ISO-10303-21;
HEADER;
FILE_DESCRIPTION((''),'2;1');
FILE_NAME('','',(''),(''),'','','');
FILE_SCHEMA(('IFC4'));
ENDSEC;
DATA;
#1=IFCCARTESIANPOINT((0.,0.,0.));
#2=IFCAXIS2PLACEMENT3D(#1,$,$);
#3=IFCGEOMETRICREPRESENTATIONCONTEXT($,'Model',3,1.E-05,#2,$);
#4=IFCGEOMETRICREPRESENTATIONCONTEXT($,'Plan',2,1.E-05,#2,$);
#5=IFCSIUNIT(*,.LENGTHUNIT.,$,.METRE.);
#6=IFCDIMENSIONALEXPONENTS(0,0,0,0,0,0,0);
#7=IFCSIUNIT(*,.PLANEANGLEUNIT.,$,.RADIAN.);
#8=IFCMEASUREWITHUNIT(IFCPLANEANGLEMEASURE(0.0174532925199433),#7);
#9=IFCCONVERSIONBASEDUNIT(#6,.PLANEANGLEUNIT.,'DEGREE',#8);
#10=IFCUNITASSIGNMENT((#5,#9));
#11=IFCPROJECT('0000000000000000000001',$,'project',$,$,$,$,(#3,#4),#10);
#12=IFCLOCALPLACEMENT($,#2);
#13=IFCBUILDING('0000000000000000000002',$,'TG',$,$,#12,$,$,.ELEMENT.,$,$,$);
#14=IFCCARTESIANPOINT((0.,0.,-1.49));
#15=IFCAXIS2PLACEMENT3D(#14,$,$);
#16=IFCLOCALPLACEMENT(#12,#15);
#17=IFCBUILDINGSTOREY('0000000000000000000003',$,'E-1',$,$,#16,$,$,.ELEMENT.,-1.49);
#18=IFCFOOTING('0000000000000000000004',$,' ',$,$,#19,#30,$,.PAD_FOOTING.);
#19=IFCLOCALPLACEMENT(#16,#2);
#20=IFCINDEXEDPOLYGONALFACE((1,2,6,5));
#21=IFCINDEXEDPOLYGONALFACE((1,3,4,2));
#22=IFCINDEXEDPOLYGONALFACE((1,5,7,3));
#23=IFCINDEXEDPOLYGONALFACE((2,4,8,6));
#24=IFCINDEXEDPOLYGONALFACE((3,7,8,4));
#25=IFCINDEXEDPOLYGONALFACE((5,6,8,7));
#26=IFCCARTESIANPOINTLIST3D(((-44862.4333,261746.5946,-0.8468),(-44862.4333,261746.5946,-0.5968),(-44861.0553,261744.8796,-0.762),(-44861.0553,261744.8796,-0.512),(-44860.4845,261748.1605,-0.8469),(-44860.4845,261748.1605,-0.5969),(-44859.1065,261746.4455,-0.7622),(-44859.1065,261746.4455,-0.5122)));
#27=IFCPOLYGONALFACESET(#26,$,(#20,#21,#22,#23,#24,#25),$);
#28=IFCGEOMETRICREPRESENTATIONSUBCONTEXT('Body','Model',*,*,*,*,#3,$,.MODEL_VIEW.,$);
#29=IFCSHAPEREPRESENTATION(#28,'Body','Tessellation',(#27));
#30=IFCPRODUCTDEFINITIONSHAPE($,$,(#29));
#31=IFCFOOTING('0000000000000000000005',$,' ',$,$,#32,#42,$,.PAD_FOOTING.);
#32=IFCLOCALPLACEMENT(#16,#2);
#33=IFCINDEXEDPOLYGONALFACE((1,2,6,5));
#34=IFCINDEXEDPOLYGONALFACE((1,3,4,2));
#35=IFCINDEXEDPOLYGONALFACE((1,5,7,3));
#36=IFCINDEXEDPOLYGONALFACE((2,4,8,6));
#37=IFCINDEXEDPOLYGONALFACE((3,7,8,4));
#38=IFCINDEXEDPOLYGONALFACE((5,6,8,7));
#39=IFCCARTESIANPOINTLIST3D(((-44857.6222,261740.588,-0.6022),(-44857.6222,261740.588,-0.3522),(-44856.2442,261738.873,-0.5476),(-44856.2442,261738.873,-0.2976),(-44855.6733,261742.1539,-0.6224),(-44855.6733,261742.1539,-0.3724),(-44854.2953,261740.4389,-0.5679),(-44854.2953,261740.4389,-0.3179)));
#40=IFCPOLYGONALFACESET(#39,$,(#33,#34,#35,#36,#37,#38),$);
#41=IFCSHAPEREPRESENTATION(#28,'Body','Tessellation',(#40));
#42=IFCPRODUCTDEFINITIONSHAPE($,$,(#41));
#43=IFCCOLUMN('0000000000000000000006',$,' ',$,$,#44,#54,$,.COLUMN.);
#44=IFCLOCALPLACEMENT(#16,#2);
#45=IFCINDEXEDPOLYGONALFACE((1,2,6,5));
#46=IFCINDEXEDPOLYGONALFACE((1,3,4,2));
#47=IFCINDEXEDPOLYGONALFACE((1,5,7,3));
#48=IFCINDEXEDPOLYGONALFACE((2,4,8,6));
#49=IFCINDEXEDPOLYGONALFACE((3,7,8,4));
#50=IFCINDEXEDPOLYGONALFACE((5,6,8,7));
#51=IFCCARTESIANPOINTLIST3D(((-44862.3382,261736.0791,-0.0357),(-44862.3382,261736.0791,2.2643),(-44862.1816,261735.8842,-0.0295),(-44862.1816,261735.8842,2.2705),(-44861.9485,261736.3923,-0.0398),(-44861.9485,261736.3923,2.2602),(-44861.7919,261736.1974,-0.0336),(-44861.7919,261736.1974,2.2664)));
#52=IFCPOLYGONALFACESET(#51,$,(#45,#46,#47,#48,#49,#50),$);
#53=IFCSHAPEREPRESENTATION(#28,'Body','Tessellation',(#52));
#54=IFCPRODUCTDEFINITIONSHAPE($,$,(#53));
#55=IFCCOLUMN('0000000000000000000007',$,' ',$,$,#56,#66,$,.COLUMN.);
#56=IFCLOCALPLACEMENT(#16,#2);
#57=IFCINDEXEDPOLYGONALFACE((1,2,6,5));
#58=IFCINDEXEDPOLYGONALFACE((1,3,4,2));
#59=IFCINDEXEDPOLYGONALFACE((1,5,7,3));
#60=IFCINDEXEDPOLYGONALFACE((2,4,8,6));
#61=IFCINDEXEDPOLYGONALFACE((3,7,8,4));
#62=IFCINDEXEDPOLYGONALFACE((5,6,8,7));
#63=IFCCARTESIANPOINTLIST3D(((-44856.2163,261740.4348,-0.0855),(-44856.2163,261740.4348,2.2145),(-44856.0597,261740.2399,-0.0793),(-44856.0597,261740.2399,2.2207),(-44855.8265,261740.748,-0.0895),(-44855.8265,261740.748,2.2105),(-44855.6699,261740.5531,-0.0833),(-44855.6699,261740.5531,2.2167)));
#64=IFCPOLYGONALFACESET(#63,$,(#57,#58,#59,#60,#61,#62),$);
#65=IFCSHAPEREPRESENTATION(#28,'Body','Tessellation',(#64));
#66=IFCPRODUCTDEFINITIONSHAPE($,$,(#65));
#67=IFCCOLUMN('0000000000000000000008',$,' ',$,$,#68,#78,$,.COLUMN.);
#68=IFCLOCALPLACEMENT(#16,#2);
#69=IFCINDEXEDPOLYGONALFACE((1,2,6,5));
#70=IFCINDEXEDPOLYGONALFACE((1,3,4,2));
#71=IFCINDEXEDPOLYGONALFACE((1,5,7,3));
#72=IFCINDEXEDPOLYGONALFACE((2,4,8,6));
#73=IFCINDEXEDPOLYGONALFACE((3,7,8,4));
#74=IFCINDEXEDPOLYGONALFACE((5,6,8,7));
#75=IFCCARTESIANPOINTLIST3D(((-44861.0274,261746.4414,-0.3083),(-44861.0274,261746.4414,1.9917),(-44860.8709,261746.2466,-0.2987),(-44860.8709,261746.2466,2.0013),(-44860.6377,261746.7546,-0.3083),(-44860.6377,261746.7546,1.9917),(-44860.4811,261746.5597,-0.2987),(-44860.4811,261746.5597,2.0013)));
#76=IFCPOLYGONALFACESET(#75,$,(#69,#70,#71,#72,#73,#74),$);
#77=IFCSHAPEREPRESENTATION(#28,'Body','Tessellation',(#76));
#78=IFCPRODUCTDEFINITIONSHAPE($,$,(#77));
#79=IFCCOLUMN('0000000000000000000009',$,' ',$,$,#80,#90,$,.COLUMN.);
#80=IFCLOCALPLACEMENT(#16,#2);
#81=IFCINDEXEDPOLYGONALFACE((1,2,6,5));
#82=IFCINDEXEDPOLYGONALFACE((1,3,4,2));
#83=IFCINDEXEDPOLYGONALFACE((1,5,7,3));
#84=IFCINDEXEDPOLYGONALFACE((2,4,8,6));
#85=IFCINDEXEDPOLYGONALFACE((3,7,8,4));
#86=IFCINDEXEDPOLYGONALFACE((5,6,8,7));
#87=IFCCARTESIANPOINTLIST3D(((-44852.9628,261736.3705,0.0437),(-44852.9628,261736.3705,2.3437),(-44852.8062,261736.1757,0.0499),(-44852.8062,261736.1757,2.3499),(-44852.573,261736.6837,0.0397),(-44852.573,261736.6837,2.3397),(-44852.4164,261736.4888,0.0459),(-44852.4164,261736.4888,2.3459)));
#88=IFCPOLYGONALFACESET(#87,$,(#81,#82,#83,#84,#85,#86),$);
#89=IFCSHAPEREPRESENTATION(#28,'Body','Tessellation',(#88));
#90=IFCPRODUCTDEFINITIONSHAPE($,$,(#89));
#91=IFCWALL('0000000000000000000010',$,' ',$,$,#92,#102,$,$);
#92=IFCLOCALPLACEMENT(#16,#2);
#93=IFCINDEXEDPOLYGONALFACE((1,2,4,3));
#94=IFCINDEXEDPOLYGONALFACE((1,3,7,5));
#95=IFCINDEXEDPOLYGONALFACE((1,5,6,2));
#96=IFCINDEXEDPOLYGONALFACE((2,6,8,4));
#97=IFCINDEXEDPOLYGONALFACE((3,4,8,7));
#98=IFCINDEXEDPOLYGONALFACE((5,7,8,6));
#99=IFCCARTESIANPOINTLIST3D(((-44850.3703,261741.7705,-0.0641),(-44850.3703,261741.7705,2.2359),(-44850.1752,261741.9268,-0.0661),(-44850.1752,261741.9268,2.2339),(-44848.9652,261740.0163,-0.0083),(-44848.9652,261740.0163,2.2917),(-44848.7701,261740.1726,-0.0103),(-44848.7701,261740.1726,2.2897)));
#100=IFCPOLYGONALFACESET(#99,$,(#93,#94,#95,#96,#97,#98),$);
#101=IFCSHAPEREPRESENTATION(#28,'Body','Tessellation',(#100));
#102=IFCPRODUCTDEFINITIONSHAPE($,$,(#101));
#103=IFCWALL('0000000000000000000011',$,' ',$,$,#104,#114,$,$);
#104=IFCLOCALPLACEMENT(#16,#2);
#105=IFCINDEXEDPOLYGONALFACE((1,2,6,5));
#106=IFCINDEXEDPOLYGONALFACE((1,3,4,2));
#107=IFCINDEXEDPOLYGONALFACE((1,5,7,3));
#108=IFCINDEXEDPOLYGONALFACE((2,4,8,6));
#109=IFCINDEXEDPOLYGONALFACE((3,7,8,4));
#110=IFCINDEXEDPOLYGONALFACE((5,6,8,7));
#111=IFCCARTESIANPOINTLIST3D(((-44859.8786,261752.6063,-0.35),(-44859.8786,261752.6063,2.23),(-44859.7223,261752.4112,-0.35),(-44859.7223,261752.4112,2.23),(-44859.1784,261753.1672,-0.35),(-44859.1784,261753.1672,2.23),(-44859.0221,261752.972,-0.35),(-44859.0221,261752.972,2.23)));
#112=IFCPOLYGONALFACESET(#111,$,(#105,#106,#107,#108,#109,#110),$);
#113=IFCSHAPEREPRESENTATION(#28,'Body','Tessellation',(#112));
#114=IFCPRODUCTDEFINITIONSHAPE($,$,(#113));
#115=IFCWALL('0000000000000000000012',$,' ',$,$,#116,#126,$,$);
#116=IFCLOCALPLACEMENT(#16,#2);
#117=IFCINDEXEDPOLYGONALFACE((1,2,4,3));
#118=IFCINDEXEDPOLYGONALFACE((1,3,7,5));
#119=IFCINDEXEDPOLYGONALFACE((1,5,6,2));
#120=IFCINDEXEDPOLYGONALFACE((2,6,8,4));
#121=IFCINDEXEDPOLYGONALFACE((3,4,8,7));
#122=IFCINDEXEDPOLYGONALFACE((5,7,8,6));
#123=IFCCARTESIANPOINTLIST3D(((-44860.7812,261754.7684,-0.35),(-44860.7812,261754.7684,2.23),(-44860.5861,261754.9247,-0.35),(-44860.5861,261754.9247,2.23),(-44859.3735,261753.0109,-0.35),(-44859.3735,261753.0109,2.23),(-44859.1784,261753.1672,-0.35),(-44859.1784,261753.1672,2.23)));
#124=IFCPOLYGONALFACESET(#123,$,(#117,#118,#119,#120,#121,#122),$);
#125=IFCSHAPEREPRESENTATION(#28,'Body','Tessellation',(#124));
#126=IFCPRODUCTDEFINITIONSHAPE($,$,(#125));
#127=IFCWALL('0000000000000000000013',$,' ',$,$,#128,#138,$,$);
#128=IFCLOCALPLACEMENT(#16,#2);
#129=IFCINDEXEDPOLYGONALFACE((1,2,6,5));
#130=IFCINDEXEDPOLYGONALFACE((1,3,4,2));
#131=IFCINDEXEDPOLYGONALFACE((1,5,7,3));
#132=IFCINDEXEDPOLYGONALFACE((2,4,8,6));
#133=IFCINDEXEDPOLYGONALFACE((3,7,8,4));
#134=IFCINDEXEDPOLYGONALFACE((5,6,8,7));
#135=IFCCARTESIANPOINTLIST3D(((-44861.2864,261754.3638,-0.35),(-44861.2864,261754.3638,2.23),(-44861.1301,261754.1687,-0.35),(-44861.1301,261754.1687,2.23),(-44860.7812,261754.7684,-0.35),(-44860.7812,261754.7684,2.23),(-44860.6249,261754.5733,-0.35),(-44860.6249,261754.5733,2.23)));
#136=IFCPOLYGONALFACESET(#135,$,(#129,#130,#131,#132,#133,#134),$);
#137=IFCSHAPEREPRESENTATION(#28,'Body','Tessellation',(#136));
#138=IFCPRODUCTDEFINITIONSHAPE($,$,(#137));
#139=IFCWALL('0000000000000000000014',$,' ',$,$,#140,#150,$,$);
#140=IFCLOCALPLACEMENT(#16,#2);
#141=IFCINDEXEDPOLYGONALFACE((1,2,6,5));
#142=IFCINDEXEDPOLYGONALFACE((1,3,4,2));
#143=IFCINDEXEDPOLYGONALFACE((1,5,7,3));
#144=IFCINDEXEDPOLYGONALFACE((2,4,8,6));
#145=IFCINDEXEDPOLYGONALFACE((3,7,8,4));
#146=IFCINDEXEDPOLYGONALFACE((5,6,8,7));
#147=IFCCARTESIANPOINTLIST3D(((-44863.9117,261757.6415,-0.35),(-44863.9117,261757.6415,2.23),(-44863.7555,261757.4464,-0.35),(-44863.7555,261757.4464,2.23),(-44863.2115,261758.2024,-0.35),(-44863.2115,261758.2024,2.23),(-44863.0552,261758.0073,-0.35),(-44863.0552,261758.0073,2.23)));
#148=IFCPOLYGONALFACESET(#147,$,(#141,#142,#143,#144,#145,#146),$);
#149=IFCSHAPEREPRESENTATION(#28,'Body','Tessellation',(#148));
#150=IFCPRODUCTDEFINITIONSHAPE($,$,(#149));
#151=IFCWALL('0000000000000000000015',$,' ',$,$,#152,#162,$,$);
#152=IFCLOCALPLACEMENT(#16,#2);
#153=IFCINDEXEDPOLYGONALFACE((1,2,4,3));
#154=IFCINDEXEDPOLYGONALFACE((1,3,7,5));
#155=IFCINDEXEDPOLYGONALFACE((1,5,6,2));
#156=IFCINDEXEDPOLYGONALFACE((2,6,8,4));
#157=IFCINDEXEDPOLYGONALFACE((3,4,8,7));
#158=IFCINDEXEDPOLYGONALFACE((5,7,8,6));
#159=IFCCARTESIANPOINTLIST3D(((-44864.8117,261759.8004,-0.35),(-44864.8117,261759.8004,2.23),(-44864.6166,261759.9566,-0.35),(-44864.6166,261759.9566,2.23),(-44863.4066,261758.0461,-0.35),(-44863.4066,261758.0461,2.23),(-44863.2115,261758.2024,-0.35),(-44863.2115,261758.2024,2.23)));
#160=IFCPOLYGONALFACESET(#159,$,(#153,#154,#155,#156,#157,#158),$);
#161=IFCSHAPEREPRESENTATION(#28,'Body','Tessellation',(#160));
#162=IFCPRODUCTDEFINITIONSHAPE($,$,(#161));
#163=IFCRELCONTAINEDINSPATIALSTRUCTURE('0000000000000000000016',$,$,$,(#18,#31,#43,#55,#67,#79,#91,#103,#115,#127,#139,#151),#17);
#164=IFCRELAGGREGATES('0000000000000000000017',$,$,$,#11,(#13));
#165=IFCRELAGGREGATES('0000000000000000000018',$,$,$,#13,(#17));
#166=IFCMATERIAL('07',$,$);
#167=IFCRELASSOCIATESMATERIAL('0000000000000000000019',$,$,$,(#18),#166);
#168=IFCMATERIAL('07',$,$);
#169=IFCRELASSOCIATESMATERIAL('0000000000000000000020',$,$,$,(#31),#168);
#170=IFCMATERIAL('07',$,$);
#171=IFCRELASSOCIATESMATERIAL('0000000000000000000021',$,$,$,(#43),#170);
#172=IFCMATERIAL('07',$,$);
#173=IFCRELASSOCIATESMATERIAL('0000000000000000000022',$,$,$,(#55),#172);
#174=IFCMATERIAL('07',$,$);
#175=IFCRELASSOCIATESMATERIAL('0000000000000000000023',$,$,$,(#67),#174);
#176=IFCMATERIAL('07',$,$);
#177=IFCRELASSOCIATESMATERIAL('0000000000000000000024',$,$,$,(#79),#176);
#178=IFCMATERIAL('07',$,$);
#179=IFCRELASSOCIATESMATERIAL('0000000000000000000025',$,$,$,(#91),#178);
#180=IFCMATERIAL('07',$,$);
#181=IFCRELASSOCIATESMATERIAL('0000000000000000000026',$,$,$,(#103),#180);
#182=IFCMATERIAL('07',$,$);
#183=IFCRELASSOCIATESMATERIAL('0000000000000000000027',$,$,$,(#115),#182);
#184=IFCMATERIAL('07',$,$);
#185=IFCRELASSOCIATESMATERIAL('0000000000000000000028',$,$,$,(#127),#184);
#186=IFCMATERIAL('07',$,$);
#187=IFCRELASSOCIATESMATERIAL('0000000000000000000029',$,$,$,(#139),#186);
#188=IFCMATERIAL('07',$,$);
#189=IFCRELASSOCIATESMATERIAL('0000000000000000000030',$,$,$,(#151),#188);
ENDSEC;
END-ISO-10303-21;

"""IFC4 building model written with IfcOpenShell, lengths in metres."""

from ifc_helpers import new_model, entity, si_unit, converted_unit, frame, frame_2d, origin, origin_with_axes, place, context, subcontext, project, spatial, rectangle, extrude, clip, halfspace, material, element, save


model = new_model("IFC4")

# Units and contexts
model_context = context("Model", 3, precision=1e-05, world=origin())
plan_context = context("Plan", 2, precision=1e-05, world=origin())
body_context = subcontext(model_context, "Body", "Model", "MODEL_VIEW")
ifc_project = project(units=[si_unit("LENGTHUNIT", "METRE"), converted_unit("PLANEANGLEUNIT", "DEGREE", entity("IfcPlaneAngleMeasure", 0.0174532925199433), si_unit("PLANEANGLEUNIT", "RADIAN"), dimensions=[0, 0, 0, 0, 0, 0, 0])], contexts=[model_context, plan_context])

# Building, storey
building_placement = place(None, origin())
building = spatial("IfcBuilding", under=ifc_project, at=building_placement, Name="TG", CompositionType="ELEMENT")
storey_placement = place(building_placement, frame((0.0, 0.0, -1.49)))
storey = spatial("IfcBuildingStorey", under=building, at=storey_placement, Name="E-1", CompositionType="ELEMENT", Elevation=-1.49)

# Footings
ifc_material_1 = material(Name="07")
footing_1_placement = place(storey_placement, frame((-44862.4333, 261744.8796, -0.8469)))
element("IfcFooting", 1, at=footing_1_placement, inside=storey, material=ifc_material_1, Name=" ", PredefinedType="PAD_FOOTING", context=body_context, shape_type="Clipping", body=[
    clip(clip(extrude(rectangle(XDim=2.5, YDim=2.2, at=frame_2d((0.2854, 1.6404), x_axis=(0.779531, 0.626364))), frame((1.378, 0.0, 0.0), z_axis=(0.0, 0.0, 1.0), x_axis=(1.0, 0.0, 0.0)), (0.0, 0.0, 1.0), 0.3349), halfspace(frame((1.6634, 1.6404, 0.0425), z_axis=(-0.024077, 0.03006, 0.999258), x_axis=(0.625899, -0.778953, 0.038513)), True)), halfspace(frame((1.6634, 1.6404, 0.2925), z_axis=(0.024077, -0.03006, -0.999258), x_axis=(0.779531, 0.626364, -0.00006)), True)),
])
ifc_material_2 = material(Name="07")
footing_2_placement = place(storey_placement, frame((-44857.6222, 261738.873, -0.6224)))
element("IfcFooting", 2, at=footing_2_placement, inside=storey, material=ifc_material_2, Name=" ", PredefinedType="PAD_FOOTING", context=body_context, shape_type="Clipping", body=[
    clip(clip(extrude(rectangle(XDim=2.5, YDim=2.2, at=frame_2d((0.2854, 1.6404), x_axis=(0.779531, 0.626364))), frame((1.378, 0.0, 0.0), z_axis=(0.0, 0.0, 1.0), x_axis=(1.0, 0.0, 0.0)), (0.0, 0.0, 1.0), 0.3248), halfspace(frame((1.6634, 1.6404, 0.0374), z_axis=(-0.009231, 0.024393, 0.99966), x_axis=(0.626171, -0.779291, 0.024798)), True)), halfspace(frame((1.6634, 1.6404, 0.2874), z_axis=(0.009231, -0.024393, -0.99966), x_axis=(0.779505, 0.626343, -0.008086)), True)),
])

# Columns
ifc_material_3 = material(Name="07")
column_1_placement = place(storey_placement, frame((-44861.9485, 261736.3923, -0.0398)))
element("IfcColumn", 3, at=column_1_placement, inside=storey, material=ifc_material_3, Name=" ", PredefinedType="COLUMN", context=body_context, shape_type="Clipping", body=[
    clip(clip(extrude(rectangle(XDim=0.5, YDim=0.25, at=frame_2d((-0.1166, -0.254), x_axis=(-0.779531, -0.626364))), origin_with_axes(), (0.0, 0.0, 1.0), 2.3102), halfspace(frame((-0.1166, -0.254, 0.0051), z_axis=(-0.009231, 0.024393, 0.99966), x_axis=(-0.626171, 0.779291, -0.024798)), True)), halfspace(frame((-0.1166, -0.254, 2.3051), z_axis=(0.009231, -0.024393, -0.99966), x_axis=(-0.779505, -0.626343, 0.008086)), True)),
])
ifc_material_4 = material(Name="07")
column_2_placement = place(storey_placement, frame((-44855.8265, 261740.748, -0.0895)))
element("IfcColumn", 4, at=column_2_placement, inside=storey, material=ifc_material_4, Name=" ", PredefinedType="COLUMN", context=body_context, shape_type="Clipping", body=[
    clip(clip(extrude(rectangle(XDim=0.5, YDim=0.25, at=frame_2d((-0.1166, -0.254), x_axis=(-0.779531, -0.626364))), origin_with_axes(), (0.0, 0.0, 1.0), 2.3102), halfspace(frame((-0.1166, -0.254, 0.0051), z_axis=(-0.009231, 0.024393, 0.99966), x_axis=(-0.626171, 0.779291, -0.024798)), True)), halfspace(frame((-0.1166, -0.254, 2.3051), z_axis=(0.009231, -0.024393, -0.99966), x_axis=(-0.779505, -0.626343, 0.008086)), True)),
])
ifc_material_5 = material(Name="07")
column_3_placement = place(storey_placement, frame((-44860.6377, 261746.7546, -0.3083)))
element("IfcColumn", 5, at=column_3_placement, inside=storey, material=ifc_material_5, Name=" ", PredefinedType="COLUMN", context=body_context, shape_type="Clipping", body=[
    clip(clip(extrude(rectangle(XDim=0.5, YDim=0.25, at=frame_2d((-0.1166, -0.254), x_axis=(-0.779531, -0.626364))), origin_with_axes(), (0.0, 0.0, 1.0), 2.3097), halfspace(frame((-0.1166, -0.254, 0.0048), z_axis=(-0.024077, 0.03006, 0.999258), x_axis=(-0.625899, 0.778953, -0.038513)), True)), halfspace(frame((-0.1166, -0.254, 2.3048), z_axis=(0.024077, -0.03006, -0.999258), x_axis=(-0.779531, -0.626364, 0.00006)), True)),
])
ifc_material_6 = material(Name="07")
column_4_placement = place(storey_placement, frame((-44852.573, 261736.6837, 0.0397)))
element("IfcColumn", 6, at=column_4_placement, inside=storey, material=ifc_material_6, Name=" ", PredefinedType="COLUMN", context=body_context, shape_type="Clipping", body=[
    clip(clip(extrude(rectangle(XDim=0.5, YDim=0.25, at=frame_2d((-0.1166, -0.254), x_axis=(-0.779531, -0.626364))), origin_with_axes(), (0.0, 0.0, 1.0), 2.3102), halfspace(frame((-0.1166, -0.254, 0.0051), z_axis=(-0.009231, 0.024393, 0.99966), x_axis=(-0.626171, 0.779291, -0.024798)), True)), halfspace(frame((-0.1166, -0.254, 2.3051), z_axis=(0.009231, -0.024393, -0.99966), x_axis=(-0.779505, -0.626343, 0.008086)), True)),
])

# Walls
ifc_material_7 = material(Name="07")
wall_1_placement = place(storey_placement, frame((-44848.7701, 261740.1726, -0.0661), z_axis=(0.0, 0.0, 1.0), x_axis=(-0.625159, 0.780498, 0.0)))
element("IfcWall", 7, at=wall_1_placement, inside=storey, material=ifc_material_7, Name=" ", context=body_context, shape_type="Clipping", body=[
    clip(clip(extrude(rectangle(XDim=2.2476, YDim=0.25, at=frame_2d((1.1238, 0.125), x_axis=(1.0, 0.0))), origin_with_axes(), (0.0, 0.0, 1.0), 2.3578), halfspace(frame((1.1238, 0.125, 0.0289), z_axis=(0.02481, -0.008045, 0.99966), x_axis=(0.0, -0.999968, -0.008047)), True)), halfspace(frame((1.1238, 0.125, 2.3289), z_axis=(-0.02481, 0.008045, -0.99966), x_axis=(0.999692, 0.0, -0.02481)), True)),
])
ifc_material_8 = material(Name="07")
wall_2_placement = place(storey_placement, frame((-44859.7223, 261752.4112, -0.35), z_axis=(0.0, 0.0, 1.0), x_axis=(0.780498, 0.625159, 0.0)))
element("IfcWall", 8, at=wall_2_placement, inside=storey, material=ifc_material_8, Name=" ", context=body_context, shape_type="SweptSolid", body=[
    extrude(rectangle(XDim=0.8972, YDim=0.25, at=frame_2d((0.4486, 0.125), x_axis=(1.0, 0.0))), origin_with_axes(), (0.0, 0.0, 1.0), 2.58),
])
ifc_material_9 = material(Name="07")
wall_3_placement = place(storey_placement, frame((-44859.1784, 261753.1672, -0.35), z_axis=(0.0, 0.0, 1.0), x_axis=(-0.625159, 0.780498, 0.0)))
element("IfcWall", 9, at=wall_3_placement, inside=storey, material=ifc_material_9, Name=" ", context=body_context, shape_type="SweptSolid", body=[
    extrude(rectangle(XDim=2.2518, YDim=0.25, at=frame_2d((1.1259, 0.125), x_axis=(1.0, 0.0))), origin_with_axes(), (0.0, 0.0, 1.0), 2.58),
])
ifc_material_10 = material(Name="07")
wall_4_placement = place(storey_placement, frame((-44860.7812, 261754.7684, -0.35), z_axis=(0.0, 0.0, 1.0), x_axis=(-0.780498, -0.625159, 0.0)))
element("IfcWall", 10, at=wall_4_placement, inside=storey, material=ifc_material_10, Name=" ", context=body_context, shape_type="SweptSolid", body=[
    extrude(rectangle(XDim=0.6472, YDim=0.25, at=frame_2d((0.3236, 0.125), x_axis=(1.0, 0.0))), origin_with_axes(), (0.0, 0.0, 1.0), 2.58),
])
ifc_material_11 = material(Name="07")
wall_5_placement = place(storey_placement, frame((-44863.7555, 261757.4464, -0.35), z_axis=(0.0, 0.0, 1.0), x_axis=(0.780498, 0.625159, 0.0)))
element("IfcWall", 11, at=wall_5_placement, inside=storey, material=ifc_material_11, Name=" ", context=body_context, shape_type="SweptSolid", body=[
    extrude(rectangle(XDim=0.8972, YDim=0.25, at=frame_2d((0.4486, 0.125), x_axis=(1.0, 0.0))), origin_with_axes(), (0.0, 0.0, 1.0), 2.58),
])
ifc_material_12 = material(Name="07")
wall_6_placement = place(storey_placement, frame((-44863.2115, 261758.2024, -0.35), z_axis=(0.0, 0.0, 1.0), x_axis=(-0.625159, 0.780498, 0.0)))
element("IfcWall", 12, at=wall_6_placement, inside=storey, material=ifc_material_12, Name=" ", context=body_context, shape_type="SweptSolid", body=[
    extrude(rectangle(XDim=2.2476, YDim=0.25, at=frame_2d((1.1238, 0.125), x_axis=(1.0, 0.0))), origin_with_axes(), (0.0, 0.0, 1.0), 2.58),
])

save(model, "model.ifc")
